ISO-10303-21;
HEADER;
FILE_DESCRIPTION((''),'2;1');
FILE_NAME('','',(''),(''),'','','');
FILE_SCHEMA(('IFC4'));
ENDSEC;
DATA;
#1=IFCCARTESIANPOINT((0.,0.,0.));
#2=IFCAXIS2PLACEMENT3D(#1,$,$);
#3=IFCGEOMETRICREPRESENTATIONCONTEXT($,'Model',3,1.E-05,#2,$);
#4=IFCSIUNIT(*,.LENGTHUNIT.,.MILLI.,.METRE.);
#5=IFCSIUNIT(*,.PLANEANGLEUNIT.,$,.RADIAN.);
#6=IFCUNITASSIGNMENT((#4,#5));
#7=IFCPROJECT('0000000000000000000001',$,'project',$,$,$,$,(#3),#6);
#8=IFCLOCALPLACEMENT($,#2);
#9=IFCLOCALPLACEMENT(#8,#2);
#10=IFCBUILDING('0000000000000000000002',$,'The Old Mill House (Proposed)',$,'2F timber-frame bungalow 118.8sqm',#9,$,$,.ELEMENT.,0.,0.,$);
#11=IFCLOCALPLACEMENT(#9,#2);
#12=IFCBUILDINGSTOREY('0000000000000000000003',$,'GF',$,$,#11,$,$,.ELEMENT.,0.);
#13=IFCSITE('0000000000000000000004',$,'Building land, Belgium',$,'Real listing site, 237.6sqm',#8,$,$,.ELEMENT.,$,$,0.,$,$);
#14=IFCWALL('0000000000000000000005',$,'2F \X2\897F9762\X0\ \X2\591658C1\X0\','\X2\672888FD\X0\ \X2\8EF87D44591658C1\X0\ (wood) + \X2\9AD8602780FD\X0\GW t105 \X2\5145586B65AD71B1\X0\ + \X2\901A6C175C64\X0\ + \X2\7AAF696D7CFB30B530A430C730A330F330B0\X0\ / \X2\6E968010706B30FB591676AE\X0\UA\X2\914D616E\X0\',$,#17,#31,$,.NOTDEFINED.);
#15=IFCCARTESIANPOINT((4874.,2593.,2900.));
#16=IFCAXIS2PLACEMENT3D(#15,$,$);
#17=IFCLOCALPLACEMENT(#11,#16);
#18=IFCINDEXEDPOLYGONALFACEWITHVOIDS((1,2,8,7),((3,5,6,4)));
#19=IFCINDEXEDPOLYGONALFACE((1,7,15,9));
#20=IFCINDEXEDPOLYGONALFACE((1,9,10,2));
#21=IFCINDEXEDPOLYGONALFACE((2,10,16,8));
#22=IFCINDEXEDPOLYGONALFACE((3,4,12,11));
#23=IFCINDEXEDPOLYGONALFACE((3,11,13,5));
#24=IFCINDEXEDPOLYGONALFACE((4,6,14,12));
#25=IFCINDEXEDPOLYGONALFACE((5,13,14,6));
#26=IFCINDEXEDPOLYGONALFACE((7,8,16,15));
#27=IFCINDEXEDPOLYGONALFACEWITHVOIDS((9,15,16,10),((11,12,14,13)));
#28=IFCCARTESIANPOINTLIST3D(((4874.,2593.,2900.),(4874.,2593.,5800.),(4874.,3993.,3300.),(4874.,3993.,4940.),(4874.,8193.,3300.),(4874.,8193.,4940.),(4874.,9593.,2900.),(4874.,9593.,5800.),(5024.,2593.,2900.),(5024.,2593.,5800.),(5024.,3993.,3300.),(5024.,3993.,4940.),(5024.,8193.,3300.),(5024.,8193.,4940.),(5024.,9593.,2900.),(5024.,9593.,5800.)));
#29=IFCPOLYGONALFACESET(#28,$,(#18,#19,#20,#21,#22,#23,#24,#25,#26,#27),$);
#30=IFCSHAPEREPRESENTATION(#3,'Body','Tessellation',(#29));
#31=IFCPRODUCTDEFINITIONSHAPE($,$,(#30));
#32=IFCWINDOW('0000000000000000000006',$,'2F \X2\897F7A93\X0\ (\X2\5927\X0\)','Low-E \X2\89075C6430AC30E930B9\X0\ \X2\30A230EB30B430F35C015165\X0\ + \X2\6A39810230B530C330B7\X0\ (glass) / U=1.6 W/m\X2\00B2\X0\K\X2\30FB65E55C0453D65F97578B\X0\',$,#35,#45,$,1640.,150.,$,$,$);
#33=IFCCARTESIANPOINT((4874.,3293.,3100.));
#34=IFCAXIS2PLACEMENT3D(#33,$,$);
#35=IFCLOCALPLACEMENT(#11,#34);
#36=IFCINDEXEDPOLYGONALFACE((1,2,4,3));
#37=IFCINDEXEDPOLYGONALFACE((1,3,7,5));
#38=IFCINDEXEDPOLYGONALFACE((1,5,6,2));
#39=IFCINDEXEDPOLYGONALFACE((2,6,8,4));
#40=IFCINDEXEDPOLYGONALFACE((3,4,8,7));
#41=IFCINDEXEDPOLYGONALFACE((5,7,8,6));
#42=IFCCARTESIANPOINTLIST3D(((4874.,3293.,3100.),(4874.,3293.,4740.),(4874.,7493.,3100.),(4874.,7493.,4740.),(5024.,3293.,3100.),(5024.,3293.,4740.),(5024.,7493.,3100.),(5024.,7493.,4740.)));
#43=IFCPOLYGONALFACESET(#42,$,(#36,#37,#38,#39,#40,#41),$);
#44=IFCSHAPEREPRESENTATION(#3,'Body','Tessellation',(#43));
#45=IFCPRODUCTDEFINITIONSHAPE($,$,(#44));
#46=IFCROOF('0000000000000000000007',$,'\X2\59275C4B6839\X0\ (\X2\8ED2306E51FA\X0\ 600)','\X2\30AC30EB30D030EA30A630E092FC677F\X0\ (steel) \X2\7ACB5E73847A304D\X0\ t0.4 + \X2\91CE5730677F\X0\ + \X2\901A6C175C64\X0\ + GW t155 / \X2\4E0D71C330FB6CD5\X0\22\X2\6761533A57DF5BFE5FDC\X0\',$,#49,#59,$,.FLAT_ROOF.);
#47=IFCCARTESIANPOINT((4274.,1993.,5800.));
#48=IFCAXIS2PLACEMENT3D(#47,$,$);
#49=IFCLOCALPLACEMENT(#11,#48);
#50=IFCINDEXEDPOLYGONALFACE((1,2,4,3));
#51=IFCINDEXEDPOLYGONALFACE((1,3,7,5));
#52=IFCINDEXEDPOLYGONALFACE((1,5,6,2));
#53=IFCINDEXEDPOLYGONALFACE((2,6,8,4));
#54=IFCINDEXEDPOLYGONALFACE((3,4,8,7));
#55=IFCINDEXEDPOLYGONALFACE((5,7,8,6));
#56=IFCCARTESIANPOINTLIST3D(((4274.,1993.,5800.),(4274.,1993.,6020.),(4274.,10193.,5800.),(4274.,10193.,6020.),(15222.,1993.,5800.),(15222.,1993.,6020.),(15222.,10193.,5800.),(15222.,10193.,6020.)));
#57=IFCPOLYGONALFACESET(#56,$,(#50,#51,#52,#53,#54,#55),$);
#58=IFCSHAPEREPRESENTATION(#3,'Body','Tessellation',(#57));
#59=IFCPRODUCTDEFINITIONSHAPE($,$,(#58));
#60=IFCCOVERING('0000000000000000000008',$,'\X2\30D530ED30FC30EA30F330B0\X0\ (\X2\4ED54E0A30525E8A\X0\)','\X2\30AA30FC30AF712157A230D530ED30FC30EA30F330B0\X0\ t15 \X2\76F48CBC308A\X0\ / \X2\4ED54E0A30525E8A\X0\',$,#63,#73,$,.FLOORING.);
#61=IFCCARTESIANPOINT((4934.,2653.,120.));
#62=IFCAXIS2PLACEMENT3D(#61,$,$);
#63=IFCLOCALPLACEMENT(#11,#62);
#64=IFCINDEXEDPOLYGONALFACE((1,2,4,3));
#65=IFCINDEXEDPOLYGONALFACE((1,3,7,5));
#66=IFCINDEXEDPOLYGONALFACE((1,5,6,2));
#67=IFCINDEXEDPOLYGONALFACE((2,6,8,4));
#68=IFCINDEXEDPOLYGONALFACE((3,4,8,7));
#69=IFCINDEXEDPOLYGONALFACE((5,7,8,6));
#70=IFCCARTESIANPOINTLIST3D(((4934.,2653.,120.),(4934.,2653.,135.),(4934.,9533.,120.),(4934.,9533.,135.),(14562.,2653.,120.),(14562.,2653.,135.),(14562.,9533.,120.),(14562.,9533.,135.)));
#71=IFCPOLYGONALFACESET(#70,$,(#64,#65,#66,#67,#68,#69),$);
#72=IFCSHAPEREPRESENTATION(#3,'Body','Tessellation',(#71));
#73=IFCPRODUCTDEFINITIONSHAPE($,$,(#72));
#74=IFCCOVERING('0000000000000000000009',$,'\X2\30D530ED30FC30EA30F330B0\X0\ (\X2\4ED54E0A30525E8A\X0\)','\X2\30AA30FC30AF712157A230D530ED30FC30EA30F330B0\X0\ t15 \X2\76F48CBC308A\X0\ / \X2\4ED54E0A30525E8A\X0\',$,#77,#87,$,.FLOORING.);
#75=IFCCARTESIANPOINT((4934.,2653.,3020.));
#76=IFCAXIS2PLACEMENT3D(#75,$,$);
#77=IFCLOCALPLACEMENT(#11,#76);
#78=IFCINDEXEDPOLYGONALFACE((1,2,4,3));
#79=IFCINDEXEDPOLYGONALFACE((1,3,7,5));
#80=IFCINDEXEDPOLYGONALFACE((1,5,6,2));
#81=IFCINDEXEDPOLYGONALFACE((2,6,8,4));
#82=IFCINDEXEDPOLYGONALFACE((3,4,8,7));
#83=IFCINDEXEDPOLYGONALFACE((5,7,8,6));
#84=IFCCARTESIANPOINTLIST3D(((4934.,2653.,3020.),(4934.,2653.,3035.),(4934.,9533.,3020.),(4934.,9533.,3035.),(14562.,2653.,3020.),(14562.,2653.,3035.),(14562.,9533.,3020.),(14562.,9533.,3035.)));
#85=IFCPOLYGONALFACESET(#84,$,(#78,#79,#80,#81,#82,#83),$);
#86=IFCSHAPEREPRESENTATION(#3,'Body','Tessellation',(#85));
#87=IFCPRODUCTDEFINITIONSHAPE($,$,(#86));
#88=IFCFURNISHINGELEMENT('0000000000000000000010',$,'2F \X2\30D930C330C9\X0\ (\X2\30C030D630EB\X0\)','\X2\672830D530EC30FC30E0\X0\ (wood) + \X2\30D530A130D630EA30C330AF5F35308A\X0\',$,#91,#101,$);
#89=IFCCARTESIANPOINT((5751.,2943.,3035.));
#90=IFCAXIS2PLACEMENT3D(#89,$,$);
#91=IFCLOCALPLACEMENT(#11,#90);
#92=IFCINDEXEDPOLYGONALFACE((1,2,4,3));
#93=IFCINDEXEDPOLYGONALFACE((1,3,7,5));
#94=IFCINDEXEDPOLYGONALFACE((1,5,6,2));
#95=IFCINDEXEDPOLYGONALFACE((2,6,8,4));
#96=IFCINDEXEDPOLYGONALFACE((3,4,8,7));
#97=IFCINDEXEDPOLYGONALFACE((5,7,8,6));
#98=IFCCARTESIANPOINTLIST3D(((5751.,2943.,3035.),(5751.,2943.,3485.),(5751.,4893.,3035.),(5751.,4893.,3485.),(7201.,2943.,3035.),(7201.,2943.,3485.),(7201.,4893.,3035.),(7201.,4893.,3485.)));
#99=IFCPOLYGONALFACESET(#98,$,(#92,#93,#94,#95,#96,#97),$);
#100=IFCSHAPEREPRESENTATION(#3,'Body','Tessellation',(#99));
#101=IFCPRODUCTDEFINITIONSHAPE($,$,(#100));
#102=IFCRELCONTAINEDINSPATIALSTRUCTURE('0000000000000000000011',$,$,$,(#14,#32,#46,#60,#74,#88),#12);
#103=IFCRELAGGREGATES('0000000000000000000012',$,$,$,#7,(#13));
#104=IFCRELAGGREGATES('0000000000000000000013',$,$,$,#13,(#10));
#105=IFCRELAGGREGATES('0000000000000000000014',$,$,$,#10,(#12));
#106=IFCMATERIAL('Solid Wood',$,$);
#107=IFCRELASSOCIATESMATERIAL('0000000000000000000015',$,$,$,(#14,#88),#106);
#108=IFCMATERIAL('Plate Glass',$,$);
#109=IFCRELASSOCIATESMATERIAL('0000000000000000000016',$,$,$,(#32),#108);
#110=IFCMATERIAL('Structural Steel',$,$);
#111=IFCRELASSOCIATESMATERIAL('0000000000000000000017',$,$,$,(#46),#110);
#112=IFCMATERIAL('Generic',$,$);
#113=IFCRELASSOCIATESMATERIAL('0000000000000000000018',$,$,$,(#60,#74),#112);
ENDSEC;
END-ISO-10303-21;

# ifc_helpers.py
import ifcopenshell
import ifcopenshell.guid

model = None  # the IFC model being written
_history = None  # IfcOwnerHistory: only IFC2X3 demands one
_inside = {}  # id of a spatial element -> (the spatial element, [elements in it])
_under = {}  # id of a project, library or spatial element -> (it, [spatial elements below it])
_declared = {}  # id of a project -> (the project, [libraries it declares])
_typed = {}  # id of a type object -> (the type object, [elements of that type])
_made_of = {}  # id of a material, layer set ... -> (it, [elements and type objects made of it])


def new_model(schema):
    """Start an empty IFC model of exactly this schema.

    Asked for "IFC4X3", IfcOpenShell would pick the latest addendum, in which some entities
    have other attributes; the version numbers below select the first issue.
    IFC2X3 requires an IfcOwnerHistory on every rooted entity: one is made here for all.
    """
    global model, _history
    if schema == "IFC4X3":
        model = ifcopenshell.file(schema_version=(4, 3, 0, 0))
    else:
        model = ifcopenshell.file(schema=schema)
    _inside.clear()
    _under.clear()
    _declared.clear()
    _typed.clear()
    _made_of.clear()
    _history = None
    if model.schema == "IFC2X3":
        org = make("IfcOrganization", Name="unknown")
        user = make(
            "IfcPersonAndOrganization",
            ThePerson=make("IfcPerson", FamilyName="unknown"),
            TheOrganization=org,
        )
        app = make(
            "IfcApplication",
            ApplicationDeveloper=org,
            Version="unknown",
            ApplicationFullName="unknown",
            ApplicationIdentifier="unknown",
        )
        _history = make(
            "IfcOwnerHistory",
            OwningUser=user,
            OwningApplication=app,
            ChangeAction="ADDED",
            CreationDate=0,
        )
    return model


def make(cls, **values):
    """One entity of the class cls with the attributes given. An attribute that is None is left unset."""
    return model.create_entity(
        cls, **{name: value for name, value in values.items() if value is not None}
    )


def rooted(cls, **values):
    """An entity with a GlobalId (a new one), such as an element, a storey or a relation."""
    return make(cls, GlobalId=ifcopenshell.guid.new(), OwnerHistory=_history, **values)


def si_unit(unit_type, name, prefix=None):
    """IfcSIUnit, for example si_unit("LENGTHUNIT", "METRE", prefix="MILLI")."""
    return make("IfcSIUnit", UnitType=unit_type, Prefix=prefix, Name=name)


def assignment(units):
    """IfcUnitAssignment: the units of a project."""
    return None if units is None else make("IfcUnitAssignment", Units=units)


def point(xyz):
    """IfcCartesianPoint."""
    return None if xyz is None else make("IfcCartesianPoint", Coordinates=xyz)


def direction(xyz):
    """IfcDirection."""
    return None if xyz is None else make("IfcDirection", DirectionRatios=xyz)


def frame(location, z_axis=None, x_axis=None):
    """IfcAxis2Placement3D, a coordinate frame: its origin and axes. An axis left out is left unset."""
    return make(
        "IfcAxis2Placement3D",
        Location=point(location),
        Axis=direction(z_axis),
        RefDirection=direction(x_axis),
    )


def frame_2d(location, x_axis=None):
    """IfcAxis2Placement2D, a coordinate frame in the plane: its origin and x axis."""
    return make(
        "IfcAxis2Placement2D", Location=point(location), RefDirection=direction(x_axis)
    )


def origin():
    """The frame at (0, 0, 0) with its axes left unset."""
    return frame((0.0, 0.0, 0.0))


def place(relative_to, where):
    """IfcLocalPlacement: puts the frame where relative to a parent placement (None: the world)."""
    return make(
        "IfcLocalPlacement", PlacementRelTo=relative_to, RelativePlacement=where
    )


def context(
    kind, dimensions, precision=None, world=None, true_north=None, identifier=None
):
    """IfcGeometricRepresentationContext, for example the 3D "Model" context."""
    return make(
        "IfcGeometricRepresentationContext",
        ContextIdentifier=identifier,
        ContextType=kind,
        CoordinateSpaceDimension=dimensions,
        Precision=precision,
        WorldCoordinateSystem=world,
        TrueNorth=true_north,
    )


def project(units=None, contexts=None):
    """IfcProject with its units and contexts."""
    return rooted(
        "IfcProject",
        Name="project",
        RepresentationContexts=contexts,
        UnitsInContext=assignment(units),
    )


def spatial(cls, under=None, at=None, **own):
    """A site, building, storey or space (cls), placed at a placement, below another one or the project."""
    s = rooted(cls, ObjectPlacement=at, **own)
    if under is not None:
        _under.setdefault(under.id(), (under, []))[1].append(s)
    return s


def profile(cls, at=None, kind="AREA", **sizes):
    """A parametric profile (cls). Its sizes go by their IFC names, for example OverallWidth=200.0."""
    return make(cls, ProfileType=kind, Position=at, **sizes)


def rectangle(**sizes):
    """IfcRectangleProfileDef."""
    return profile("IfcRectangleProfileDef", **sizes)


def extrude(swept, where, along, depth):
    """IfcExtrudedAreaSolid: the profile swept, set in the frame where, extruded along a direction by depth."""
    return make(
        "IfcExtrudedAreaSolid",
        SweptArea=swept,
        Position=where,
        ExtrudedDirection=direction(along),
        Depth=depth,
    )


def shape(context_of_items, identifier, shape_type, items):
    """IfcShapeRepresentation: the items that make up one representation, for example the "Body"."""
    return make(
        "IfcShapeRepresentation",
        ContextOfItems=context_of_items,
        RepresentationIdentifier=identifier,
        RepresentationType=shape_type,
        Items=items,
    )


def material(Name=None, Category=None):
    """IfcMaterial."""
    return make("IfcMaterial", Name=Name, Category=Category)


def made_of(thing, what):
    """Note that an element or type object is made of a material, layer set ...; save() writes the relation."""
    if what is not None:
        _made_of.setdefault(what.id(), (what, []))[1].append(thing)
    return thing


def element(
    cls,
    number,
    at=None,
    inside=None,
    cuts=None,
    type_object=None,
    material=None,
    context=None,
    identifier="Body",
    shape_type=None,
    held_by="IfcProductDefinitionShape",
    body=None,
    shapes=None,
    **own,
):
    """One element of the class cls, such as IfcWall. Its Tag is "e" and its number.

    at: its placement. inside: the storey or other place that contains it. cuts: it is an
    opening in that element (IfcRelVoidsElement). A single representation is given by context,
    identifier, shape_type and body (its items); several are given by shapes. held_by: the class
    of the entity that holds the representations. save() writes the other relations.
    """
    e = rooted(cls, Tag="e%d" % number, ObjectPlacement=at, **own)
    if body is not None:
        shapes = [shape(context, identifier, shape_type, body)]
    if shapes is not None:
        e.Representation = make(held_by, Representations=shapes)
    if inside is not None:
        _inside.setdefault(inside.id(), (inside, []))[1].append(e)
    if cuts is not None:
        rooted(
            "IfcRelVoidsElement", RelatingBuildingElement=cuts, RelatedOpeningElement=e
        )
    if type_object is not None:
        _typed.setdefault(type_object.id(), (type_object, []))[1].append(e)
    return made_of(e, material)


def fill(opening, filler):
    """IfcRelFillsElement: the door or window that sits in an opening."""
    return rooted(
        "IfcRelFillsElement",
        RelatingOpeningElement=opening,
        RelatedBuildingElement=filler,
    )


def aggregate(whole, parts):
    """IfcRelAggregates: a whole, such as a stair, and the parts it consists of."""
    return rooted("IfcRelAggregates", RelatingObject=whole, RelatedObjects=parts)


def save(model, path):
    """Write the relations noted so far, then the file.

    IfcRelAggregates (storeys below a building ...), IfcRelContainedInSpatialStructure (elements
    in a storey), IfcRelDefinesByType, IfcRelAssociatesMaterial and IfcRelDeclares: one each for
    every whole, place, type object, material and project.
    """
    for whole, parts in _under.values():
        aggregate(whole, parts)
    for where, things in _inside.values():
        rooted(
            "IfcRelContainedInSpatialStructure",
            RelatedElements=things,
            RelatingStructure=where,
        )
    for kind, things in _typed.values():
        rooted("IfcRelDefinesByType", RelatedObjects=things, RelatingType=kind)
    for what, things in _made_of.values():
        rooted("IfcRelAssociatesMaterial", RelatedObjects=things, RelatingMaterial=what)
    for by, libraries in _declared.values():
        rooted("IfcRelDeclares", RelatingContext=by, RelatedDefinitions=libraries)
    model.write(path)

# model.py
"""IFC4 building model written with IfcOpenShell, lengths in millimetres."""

from ifc_helpers import new_model, si_unit, frame, frame_2d, origin, place, context, project, spatial, rectangle, extrude, material, element, fill, save


model = new_model("IFC4")

# Units and contexts
model_context = context("Model", 3, precision=1e-05, world=origin())
ifc_project = project(units=[si_unit("LENGTHUNIT", "METRE", prefix="MILLI"), si_unit("PLANEANGLEUNIT", "RADIAN")], contexts=[model_context])

# Site, building, storey
site_placement = place(None, origin())
site = spatial("IfcSite", under=ifc_project, at=site_placement, Name="Building land, Belgium", ObjectType="Real listing site, 237.6sqm", CompositionType="ELEMENT", RefElevation=0.0)
building_placement = place(site_placement, origin())
building = spatial("IfcBuilding", under=site, at=building_placement, Name="The Old Mill House (Proposed)", ObjectType="2F timber-frame bungalow 118.8sqm", CompositionType="ELEMENT", ElevationOfRefHeight=0.0, ElevationOfTerrain=0.0)
storey_placement = place(building_placement, origin())
storey = spatial("IfcBuildingStorey", under=building, at=storey_placement, Name="GF", CompositionType="ELEMENT", Elevation=0.0)

# Shared definitions
ifc_material_1 = material(Name="Solid Wood")

# Shared definitions
ifc_material_2 = material(Name="Plate Glass")

# Wall, opening, window
wall_1_placement = place(storey_placement, frame((4874.0, 2593.0, 2900.0)))
wall_1 = element("IfcWall", 1, at=wall_1_placement, inside=storey, material=ifc_material_1, Name="2F 西面 外壁", Description="木製 軸組外壁 (wood) + 高性能GW t105 充填断熱 + 通気層 + 窯業系サイディング / 準耐火・外皮UA配慮", PredefinedType="NOTDEFINED", context=model_context, shape_type="SweptSolid", body=[
    extrude(rectangle(XDim=150.0, YDim=7000.0, at=frame_2d((75.0, 3500.0))), frame((4874.0, 2593.0, 2900.0)), (0.0, 0.0, 1.0), 2900.0),
])
opening_1_placement = place(storey_placement, frame((4874.0, 3293.0, 3100.0)))
opening_1 = element("IfcOpeningElement", 2, at=opening_1_placement, cuts=wall_1, PredefinedType="NOTDEFINED", context=model_context, shape_type="SweptSolid", body=[
    extrude(rectangle(XDim=150.0, YDim=4200.0, at=frame_2d((75.0, 2100.0))), frame((4874.0, 3293.0, 3100.0)), (0.0, 0.0, 1.0), 1640.0),
])
window_1_placement = place(storey_placement, frame((4874.0, 3293.0, 3100.0)))
window_1 = element("IfcWindow", 3, at=window_1_placement, inside=storey, material=ifc_material_2, Name="2F 西窓 (大)", Description="Low-E 複層ガラス アルゴン封入 + 樹脂サッシ (glass) / U=1.6 W/m²K・日射取得型", OverallHeight=1640.0, OverallWidth=150.0, context=model_context, shape_type="SweptSolid", body=[
    extrude(rectangle(XDim=150.0, YDim=4200.0, at=frame_2d((75.0, 2100.0))), frame((4874.0, 3293.0, 3100.0)), (0.0, 0.0, 1.0), 1640.0),
])
fill(opening_1, window_1)

# Roof
ifc_material_3 = material(Name="Structural Steel")
roof_placement = place(storey_placement, frame((4274.0, 1993.0, 5800.0)))
element("IfcRoof", 4, at=roof_placement, inside=storey, material=ifc_material_3, Name="大屋根 (軒の出 600)", Description="ガルバリウム鋼板 (steel) 立平葺き t0.4 + 野地板 + 通気層 + GW t155 / 不燃・法22条区域対応", PredefinedType="FLAT_ROOF", context=model_context, shape_type="SweptSolid", body=[
    extrude(rectangle(XDim=10948.0, YDim=8200.0, at=frame_2d((5474.0, 4100.0))), frame((4274.0, 1993.0, 5800.0)), (0.0, 0.0, 1.0), 220.0),
])

# Coverings
ifc_material_4 = material(Name="Generic")
covering_1_placement = place(storey_placement, frame((4934.0, 2653.0, 120.0)))
element("IfcCovering", 5, at=covering_1_placement, inside=storey, material=ifc_material_4, Name="フローリング (仕上げ床)", Description="オーク無垢フローリング t15 直貼り / 仕上げ床", PredefinedType="FLOORING", context=model_context, shape_type="SweptSolid", body=[
    extrude(rectangle(XDim=9628.0, YDim=6880.0, at=frame_2d((4814.0, 3440.0))), frame((4934.0, 2653.0, 120.0)), (0.0, 0.0, 1.0), 15.0),
])
covering_2_placement = place(storey_placement, frame((4934.0, 2653.0, 3020.0)))
element("IfcCovering", 6, at=covering_2_placement, inside=storey, material=ifc_material_4, Name="フローリング (仕上げ床)", Description="オーク無垢フローリング t15 直貼り / 仕上げ床", PredefinedType="FLOORING", context=model_context, shape_type="SweptSolid", body=[
    extrude(rectangle(XDim=9628.0, YDim=6880.0, at=frame_2d((4814.0, 3440.0))), frame((4934.0, 2653.0, 3020.0)), (0.0, 0.0, 1.0), 15.0),
])

# Furnishing element
furnishing_placement = place(storey_placement, frame((5751.0, 2943.0, 3035.0)))
element("IfcFurnishingElement", 7, at=furnishing_placement, inside=storey, material=ifc_material_1, Name="2F ベッド (ダブル)", Description="木フレーム (wood) + ファブリック張り", context=model_context, shape_type="SweptSolid", body=[
    extrude(rectangle(XDim=1450.0, YDim=1950.0, at=frame_2d((725.0, 975.0))), frame((5751.0, 2943.0, 3035.0)), (0.0, 0.0, 1.0), 450.0),
])

save(model, "model.ifc")
